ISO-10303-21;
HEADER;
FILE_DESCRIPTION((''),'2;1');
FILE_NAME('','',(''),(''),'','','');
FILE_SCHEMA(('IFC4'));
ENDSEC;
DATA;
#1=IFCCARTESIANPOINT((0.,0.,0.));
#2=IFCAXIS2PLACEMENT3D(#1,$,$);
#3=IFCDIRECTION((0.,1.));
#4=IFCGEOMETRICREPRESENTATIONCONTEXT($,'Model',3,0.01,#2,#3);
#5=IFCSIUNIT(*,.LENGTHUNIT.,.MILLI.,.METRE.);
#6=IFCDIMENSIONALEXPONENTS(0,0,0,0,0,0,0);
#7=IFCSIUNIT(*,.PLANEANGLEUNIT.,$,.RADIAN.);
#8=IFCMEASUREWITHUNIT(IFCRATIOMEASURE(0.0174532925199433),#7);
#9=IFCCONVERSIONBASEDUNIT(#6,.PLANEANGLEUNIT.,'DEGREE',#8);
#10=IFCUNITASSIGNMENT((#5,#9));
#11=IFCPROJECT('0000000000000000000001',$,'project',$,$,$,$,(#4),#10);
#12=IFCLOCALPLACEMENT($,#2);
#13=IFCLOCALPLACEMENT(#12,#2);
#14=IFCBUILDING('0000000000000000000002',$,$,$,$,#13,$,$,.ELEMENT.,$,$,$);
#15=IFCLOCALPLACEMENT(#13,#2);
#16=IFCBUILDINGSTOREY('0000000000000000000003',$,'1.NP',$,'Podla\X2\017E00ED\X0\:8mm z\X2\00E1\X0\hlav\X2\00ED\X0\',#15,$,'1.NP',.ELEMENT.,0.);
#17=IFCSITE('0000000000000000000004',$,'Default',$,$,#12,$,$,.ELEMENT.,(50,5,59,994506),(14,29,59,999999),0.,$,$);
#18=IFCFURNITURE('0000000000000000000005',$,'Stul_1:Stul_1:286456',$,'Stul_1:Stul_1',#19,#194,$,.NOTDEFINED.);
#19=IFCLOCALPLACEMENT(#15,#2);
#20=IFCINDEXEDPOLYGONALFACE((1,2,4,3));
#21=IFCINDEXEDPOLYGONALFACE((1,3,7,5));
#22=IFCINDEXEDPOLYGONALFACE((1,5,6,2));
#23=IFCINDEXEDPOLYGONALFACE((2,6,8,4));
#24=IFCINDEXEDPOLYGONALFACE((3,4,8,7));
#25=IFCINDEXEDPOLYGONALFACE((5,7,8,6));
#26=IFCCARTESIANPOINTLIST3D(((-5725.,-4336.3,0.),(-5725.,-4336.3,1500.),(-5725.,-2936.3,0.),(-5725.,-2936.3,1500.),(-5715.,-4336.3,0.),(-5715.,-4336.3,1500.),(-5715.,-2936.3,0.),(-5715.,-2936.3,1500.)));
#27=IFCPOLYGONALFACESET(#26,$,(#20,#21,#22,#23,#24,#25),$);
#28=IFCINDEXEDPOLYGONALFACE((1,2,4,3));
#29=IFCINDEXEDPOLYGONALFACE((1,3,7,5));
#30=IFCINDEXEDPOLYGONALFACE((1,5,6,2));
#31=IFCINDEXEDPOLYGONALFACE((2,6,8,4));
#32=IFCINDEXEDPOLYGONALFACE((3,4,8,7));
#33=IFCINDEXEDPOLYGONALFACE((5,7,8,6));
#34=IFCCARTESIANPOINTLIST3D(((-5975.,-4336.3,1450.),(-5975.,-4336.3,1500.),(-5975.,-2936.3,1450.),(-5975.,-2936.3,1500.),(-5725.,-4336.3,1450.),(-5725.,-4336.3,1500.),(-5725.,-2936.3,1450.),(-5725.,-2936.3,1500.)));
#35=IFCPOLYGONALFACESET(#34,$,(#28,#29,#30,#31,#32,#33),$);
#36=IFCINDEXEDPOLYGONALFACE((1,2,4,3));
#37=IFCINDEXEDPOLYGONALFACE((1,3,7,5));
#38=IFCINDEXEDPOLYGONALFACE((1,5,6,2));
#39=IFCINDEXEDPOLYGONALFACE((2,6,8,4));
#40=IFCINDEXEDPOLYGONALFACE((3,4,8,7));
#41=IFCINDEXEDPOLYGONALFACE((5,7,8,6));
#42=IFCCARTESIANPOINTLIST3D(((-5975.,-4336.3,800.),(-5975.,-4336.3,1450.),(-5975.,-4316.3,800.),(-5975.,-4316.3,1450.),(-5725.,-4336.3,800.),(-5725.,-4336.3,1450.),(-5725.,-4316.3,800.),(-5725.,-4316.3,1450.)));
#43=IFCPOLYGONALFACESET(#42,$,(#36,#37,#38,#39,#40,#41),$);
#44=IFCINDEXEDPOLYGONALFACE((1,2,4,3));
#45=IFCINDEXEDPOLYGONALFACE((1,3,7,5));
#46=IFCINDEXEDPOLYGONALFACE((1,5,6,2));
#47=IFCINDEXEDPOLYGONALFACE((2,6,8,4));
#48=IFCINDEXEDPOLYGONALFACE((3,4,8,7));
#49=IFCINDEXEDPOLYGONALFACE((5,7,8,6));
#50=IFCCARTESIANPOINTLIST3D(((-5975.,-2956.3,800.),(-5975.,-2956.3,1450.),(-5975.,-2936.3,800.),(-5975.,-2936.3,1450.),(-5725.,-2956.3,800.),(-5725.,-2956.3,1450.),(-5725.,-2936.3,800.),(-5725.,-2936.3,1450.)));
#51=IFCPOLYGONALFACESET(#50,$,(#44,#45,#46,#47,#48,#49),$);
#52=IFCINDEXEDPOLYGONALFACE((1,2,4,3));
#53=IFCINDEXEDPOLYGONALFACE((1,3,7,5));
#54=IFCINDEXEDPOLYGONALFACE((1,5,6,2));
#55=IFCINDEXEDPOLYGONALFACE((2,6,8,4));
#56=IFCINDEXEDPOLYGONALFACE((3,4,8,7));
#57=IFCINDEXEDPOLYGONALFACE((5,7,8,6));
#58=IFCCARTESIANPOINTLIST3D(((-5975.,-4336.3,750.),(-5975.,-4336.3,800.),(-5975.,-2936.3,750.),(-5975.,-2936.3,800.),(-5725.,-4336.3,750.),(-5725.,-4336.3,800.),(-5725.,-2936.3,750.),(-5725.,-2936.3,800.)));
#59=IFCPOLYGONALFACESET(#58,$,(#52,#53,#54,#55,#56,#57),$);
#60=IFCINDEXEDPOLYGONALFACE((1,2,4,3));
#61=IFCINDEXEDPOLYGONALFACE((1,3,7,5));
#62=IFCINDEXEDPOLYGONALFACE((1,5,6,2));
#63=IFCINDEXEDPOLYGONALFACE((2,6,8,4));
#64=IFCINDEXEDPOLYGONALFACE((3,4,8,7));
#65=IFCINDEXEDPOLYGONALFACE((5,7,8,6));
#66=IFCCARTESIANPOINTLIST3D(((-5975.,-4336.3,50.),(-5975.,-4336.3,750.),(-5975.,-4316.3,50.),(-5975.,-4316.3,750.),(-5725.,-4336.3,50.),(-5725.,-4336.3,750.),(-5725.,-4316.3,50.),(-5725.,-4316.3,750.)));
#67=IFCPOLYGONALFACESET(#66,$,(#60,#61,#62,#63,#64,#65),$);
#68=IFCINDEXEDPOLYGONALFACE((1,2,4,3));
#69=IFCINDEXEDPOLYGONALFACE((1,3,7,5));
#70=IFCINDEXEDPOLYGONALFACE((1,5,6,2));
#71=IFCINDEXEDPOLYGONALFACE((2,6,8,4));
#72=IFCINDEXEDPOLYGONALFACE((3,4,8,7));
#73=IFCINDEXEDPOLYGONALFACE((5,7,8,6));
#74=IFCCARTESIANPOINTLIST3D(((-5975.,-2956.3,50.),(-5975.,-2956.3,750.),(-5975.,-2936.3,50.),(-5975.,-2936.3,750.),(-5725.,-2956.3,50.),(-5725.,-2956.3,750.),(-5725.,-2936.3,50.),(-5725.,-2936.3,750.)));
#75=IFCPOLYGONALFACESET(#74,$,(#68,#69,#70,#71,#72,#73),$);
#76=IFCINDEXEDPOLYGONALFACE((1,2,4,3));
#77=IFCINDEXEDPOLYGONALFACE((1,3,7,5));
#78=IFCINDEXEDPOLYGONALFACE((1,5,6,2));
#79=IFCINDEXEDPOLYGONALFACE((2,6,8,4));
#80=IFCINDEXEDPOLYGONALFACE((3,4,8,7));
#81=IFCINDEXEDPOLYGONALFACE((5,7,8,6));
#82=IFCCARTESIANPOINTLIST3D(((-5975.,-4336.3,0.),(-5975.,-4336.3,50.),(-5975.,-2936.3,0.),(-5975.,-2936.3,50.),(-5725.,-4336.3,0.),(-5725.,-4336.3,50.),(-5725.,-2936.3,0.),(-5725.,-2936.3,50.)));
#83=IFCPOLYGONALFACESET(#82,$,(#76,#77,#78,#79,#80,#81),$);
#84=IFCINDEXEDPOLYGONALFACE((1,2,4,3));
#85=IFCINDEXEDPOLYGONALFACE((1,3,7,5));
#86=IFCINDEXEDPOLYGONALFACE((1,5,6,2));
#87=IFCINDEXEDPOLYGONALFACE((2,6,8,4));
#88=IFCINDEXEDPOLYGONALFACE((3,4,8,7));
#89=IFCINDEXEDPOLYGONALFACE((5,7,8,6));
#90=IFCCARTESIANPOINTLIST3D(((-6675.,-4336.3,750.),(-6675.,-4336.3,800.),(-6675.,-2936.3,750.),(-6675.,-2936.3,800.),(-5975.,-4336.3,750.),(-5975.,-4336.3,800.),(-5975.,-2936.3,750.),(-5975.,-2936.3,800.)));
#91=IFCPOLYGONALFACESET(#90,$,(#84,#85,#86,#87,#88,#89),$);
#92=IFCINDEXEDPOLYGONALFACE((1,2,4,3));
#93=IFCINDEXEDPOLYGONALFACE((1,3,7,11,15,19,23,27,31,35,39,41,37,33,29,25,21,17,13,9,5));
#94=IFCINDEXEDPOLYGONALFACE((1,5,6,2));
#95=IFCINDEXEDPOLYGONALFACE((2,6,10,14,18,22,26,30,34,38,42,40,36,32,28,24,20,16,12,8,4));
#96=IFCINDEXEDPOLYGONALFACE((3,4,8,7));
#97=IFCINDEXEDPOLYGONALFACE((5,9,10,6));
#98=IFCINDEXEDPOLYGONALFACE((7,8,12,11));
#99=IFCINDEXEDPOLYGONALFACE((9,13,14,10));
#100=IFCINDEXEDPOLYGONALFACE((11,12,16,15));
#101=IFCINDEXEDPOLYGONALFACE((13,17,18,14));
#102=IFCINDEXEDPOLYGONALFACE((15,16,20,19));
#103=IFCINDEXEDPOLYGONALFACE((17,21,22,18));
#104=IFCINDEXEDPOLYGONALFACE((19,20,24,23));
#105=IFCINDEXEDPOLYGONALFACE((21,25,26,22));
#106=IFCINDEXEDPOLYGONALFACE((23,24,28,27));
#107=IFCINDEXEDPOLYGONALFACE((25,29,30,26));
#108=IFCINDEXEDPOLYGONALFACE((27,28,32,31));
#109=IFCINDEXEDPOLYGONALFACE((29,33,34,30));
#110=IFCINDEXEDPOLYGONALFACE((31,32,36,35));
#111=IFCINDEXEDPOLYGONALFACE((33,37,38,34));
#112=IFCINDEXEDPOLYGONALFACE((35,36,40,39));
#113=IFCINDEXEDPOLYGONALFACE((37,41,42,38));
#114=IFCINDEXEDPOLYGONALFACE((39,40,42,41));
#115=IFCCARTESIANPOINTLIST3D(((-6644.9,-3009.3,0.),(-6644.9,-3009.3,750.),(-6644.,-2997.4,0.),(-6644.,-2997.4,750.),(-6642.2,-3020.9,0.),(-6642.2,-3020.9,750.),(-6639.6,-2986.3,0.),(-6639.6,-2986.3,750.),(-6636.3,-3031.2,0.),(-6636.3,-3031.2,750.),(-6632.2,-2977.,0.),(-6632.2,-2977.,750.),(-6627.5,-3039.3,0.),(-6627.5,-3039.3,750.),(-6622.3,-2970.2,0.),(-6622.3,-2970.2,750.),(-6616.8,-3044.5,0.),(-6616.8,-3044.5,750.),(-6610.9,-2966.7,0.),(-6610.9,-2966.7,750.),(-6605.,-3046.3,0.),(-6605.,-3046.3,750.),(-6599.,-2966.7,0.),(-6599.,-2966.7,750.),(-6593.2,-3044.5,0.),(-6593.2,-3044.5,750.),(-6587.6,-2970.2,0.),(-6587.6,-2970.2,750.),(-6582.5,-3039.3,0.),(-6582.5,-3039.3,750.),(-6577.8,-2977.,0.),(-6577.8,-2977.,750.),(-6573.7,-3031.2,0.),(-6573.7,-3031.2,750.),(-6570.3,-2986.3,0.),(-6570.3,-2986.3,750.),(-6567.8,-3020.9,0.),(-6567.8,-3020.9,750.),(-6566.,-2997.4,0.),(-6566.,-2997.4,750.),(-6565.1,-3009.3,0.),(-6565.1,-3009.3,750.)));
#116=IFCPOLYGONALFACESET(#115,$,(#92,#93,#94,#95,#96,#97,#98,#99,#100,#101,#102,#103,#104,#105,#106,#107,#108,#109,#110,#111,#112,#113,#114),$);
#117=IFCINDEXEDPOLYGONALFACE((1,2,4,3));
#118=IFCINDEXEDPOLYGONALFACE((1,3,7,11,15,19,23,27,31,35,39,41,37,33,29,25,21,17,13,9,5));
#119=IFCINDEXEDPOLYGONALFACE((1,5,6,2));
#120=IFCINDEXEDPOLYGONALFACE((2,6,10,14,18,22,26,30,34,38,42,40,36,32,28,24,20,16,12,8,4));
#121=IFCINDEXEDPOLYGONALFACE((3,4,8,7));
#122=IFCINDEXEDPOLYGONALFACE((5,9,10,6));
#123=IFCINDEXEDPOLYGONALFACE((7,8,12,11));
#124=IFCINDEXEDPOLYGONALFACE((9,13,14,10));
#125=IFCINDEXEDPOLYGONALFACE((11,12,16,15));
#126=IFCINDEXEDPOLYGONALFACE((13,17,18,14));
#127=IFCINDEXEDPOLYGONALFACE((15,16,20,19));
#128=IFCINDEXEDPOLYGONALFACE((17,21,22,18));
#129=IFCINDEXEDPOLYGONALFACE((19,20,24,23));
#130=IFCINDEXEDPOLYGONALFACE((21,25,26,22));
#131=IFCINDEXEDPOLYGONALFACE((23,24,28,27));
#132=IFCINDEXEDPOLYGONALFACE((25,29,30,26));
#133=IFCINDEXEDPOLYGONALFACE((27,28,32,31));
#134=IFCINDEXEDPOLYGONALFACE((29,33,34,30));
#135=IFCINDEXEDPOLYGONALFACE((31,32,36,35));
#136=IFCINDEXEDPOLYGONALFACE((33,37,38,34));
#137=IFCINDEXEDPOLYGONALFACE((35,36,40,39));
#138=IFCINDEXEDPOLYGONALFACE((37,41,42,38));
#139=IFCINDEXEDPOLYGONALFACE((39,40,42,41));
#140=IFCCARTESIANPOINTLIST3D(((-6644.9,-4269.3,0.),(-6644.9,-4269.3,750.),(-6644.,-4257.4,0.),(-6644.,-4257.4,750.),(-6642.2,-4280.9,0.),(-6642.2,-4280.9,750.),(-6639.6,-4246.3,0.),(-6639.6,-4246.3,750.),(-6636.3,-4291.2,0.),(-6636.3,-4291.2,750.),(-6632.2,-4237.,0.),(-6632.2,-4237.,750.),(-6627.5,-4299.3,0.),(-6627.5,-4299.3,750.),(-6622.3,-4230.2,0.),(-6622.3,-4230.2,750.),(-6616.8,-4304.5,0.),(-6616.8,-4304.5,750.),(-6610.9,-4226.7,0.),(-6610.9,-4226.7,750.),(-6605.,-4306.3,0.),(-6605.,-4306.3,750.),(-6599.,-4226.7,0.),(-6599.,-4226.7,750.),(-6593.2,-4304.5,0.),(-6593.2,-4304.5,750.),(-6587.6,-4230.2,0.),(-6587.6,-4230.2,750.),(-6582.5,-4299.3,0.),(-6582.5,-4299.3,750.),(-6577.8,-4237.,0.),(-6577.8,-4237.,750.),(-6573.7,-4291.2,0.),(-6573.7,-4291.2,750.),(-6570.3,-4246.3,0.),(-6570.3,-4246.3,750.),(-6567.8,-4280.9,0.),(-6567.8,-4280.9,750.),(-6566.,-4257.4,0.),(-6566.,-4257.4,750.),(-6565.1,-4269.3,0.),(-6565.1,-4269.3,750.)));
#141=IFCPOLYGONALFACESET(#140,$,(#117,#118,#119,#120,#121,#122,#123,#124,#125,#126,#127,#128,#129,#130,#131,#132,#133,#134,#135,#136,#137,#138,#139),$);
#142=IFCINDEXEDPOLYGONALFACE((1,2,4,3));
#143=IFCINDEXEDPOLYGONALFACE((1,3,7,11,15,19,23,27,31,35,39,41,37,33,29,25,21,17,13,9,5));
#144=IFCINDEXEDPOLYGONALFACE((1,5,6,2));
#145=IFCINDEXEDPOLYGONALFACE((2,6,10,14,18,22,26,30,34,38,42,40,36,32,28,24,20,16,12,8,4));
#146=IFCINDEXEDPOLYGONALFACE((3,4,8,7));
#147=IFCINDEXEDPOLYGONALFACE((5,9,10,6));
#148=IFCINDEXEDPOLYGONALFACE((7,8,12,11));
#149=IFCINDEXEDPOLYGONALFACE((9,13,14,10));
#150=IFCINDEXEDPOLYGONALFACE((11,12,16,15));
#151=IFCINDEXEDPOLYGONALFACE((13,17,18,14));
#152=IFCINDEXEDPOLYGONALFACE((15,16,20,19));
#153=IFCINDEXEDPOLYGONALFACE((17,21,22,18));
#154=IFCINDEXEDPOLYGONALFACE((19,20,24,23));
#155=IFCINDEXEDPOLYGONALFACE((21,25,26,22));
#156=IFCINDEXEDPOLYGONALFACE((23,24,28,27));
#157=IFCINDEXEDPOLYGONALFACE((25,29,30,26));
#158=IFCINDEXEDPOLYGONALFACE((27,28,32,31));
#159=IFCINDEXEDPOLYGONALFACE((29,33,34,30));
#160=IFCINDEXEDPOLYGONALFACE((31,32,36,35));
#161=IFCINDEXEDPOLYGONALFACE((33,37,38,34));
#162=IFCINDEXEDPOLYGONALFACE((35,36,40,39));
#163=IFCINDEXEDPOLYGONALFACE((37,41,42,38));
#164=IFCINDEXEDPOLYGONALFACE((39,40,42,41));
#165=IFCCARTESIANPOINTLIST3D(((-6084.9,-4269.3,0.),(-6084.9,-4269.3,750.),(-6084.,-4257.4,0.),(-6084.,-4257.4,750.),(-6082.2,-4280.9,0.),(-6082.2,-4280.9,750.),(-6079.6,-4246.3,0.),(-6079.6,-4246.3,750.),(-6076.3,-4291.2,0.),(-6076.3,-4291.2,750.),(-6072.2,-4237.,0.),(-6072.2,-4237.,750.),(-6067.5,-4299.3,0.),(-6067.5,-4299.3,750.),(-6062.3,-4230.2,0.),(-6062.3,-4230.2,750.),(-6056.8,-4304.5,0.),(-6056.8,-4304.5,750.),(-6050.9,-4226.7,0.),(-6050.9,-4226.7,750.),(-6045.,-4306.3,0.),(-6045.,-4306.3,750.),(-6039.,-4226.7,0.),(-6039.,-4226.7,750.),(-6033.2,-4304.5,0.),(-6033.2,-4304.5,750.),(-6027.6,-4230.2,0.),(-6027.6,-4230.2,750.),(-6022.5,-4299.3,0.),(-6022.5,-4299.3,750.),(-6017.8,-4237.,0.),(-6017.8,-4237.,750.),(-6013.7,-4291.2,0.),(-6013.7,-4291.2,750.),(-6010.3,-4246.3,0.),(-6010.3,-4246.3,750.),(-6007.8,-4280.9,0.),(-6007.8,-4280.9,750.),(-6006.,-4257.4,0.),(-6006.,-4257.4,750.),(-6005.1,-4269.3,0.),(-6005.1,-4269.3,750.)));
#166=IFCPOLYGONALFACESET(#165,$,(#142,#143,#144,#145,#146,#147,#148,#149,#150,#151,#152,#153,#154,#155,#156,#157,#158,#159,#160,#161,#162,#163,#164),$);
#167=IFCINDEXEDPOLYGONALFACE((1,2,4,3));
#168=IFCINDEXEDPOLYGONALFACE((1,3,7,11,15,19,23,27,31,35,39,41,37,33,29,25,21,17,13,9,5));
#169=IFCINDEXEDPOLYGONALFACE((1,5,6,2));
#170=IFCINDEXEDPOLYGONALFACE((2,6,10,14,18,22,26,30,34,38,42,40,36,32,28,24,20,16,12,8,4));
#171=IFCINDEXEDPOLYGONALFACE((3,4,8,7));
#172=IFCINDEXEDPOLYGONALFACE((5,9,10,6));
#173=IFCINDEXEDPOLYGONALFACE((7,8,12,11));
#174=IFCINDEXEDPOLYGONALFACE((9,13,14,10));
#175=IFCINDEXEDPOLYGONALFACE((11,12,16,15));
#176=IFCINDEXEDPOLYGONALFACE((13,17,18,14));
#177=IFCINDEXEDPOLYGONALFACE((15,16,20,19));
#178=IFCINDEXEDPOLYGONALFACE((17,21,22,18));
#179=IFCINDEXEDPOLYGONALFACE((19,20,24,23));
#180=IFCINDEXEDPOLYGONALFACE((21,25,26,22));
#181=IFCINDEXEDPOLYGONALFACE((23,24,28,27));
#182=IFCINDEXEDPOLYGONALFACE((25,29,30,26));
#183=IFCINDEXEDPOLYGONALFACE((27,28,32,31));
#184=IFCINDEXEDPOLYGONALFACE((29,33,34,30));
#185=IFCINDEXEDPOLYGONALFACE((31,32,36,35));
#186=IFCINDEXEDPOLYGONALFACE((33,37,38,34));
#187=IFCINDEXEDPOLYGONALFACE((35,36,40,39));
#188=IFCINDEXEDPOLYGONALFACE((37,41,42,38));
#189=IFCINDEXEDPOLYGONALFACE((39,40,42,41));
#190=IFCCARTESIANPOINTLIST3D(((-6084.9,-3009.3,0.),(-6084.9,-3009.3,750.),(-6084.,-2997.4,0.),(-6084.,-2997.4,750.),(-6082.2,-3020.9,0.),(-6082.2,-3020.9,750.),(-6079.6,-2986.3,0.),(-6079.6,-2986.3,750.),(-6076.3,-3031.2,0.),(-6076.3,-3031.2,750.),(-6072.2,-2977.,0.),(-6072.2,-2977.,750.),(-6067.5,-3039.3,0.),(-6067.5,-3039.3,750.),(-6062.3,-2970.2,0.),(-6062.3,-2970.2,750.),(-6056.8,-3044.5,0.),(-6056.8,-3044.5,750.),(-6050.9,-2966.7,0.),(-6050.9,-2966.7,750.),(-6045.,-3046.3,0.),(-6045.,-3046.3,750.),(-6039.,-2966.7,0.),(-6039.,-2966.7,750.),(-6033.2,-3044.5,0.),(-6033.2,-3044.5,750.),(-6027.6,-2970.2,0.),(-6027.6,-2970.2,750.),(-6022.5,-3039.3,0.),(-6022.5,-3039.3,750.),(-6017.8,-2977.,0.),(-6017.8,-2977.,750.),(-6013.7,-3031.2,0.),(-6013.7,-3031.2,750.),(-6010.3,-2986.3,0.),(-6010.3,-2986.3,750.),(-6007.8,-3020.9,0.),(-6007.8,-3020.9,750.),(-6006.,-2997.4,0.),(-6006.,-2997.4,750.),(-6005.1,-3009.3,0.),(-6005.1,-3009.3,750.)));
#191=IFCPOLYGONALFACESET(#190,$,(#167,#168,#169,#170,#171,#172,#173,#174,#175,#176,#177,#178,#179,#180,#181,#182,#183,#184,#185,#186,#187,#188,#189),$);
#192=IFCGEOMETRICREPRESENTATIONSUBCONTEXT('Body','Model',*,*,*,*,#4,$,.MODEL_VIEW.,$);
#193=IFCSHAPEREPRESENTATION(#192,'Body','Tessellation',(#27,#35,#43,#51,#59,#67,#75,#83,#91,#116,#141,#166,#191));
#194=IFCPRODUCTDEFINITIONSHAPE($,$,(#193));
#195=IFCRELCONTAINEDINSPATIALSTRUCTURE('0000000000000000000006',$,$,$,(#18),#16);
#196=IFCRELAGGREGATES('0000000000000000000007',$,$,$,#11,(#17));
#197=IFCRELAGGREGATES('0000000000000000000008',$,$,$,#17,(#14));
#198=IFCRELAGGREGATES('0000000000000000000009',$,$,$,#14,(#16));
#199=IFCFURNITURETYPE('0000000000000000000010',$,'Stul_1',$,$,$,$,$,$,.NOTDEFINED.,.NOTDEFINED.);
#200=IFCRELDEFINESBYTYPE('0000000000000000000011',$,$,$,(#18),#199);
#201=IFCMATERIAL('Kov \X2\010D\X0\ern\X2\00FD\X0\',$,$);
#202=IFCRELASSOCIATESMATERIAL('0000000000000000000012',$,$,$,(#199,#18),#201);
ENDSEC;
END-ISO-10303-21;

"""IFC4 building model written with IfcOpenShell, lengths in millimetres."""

from ifc_helpers import new_model, entity, si_unit, converted_unit, direction, frame, frame_2d, origin, origin_2d_with_axis, place, context, subcontext, project, spatial, rectangle, circle, extrude, source, transform, mapped, material, type_object, type_shapes, element, save


model = new_model("IFC4")

# Units and contexts
model_context = context("Model", 3, precision=0.01, world=origin(), true_north=direction((0.0, 1.0)))
body_context = subcontext(model_context, "Body", "Model", "MODEL_VIEW")
ifc_project = project(units=[si_unit("LENGTHUNIT", "METRE", prefix="MILLI"), converted_unit("PLANEANGLEUNIT", "DEGREE", entity("IfcRatioMeasure", 0.0174532925199433), si_unit("PLANEANGLEUNIT", "RADIAN"), dimensions=[0, 0, 0, 0, 0, 0, 0])], contexts=[model_context])

# Site, building, storey
site_placement = place(None, origin())
site = spatial("IfcSite", under=ifc_project, at=site_placement, Name="Default", CompositionType="ELEMENT", RefLatitude=(50, 5, 59, 994506), RefLongitude=(14, 29, 59, 999999), RefElevation=0.0)
building_placement = place(site_placement, origin())
building = spatial("IfcBuilding", under=site, at=building_placement, CompositionType="ELEMENT")
storey_placement = place(building_placement, origin())
storey = spatial("IfcBuildingStorey", under=building, at=storey_placement, Name="1.NP", ObjectType="Podlaží:8mm záhlaví", LongName="1.NP", CompositionType="ELEMENT", Elevation=0.0)

# Furniture
ifc_material_1 = material(Name="Kov černý")
furniture_type = type_object("IfcFurnitureType", Name="Stul_1", AssemblyPlace="NOTDEFINED", PredefinedType="NOTDEFINED", material=ifc_material_1)
shared_shape_1 = source(origin(), body_context, "Body", "SweptSolid", [
    extrude(rectangle(XDim=1400.0, YDim=10.0, at=origin_2d_with_axis()), frame((0.0, 605.0, 0.0), z_axis=(0.0, 0.0, 1.0), x_axis=(-1.0, 0.0, 0.0)), (0.0, 0.0, 1.0), 1500.0),
    extrude(rectangle(XDim=1400.0, YDim=250.0, at=frame_2d((0.0, 0.0), x_axis=(1.0, 0.0))), frame((0.0, 475.0, 1450.0), z_axis=(0.0, 0.0, 1.0), x_axis=(-1.0, 0.0, 0.0)), (0.0, 0.0, 1.0), 50.0),
    extrude(rectangle(XDim=20.0, YDim=250.0, at=origin_2d_with_axis()), frame((690.0, 475.0, 800.0), z_axis=(0.0, 0.0, 1.0), x_axis=(-1.0, 0.0, 0.0)), (0.0, 0.0, 1.0), 650.0),
    extrude(rectangle(XDim=20.0, YDim=250.0, at=frame_2d((0.0, 0.0), x_axis=(1.0, 0.0))), frame((-690.0, 475.0, 800.0), z_axis=(0.0, 0.0, 1.0), x_axis=(-1.0, 0.0, 0.0)), (0.0, 0.0, 1.0), 650.0),
    extrude(rectangle(XDim=1400.0, YDim=250.0, at=origin_2d_with_axis()), frame((0.0, 475.0, 750.0), z_axis=(0.0, 0.0, 1.0), x_axis=(-1.0, 0.0, 0.0)), (0.0, 0.0, 1.0), 50.0),
    extrude(rectangle(XDim=20.0, YDim=250.0, at=origin_2d_with_axis()), frame((690.0, 475.0, 50.0), z_axis=(0.0, 0.0, 1.0), x_axis=(-1.0, 0.0, 0.0)), (0.0, 0.0, 1.0), 700.0),
    extrude(rectangle(XDim=20.0, YDim=250.0, at=frame_2d((0.0, 0.0), x_axis=(1.0, 0.0))), frame((-690.0, 475.0, 50.0), z_axis=(0.0, 0.0, 1.0), x_axis=(-1.0, 0.0, 0.0)), (0.0, 0.0, 1.0), 700.0),
    extrude(rectangle(XDim=1400.0, YDim=250.0, at=origin_2d_with_axis()), frame((0.0, 475.0, 0.0), z_axis=(0.0, 0.0, 1.0), x_axis=(-1.0, 0.0, 0.0)), (0.0, 0.0, 1.0), 50.0),
    extrude(rectangle(XDim=1400.0, YDim=700.0, at=origin_2d_with_axis()), frame((0.0, 0.0, 750.0), z_axis=(0.0, 0.0, 1.0), x_axis=(-1.0, 0.0, 0.0)), (0.0, 0.0, 1.0), 50.0),
    extrude(circle(Radius=40.0, at=frame_2d((0.0, 0.0), x_axis=(1.0, 0.0))), frame((-630.0, -280.0, 0.0)), (0.0, 0.0, 1.0), 750.0),
    extrude(circle(Radius=40.0, at=frame_2d((0.0, 0.0), x_axis=(1.0, 0.0))), frame((630.0, -280.0, 0.0)), (0.0, 0.0, 1.0), 750.0),
    extrude(circle(Radius=40.0, at=frame_2d((0.0, 0.0), x_axis=(1.0, 0.0))), frame((630.0, 280.0, 0.0)), (0.0, 0.0, 1.0), 750.0),
    extrude(circle(Radius=40.0, at=frame_2d((0.0, 0.0), x_axis=(1.0, 0.0))), frame((-630.0, 280.0, 0.0)), (0.0, 0.0, 1.0), 750.0),
])
type_shapes(furniture_type, [shared_shape_1])
for number, where, z_axis, x_axis, name in (
    (1, (-6325.0, -3636.3, 0.0), (0.0, 0.0, 1.0), (0.0, -1.0, 0.0), "Stul_1:Stul_1:286456"),
):
    element("IfcFurniture", number, at=place(storey_placement, frame(where, z_axis=z_axis, x_axis=x_axis)), inside=storey, type_object=furniture_type, material=ifc_material_1, Name=name, ObjectType="Stul_1:Stul_1", PredefinedType="NOTDEFINED", context=body_context, shape_type="MappedRepresentation", body=[
        mapped(shared_shape_1, transform((0.0, 0.0, 0.0), scale=1.0)),
    ])

save(model, "model.ifc")
